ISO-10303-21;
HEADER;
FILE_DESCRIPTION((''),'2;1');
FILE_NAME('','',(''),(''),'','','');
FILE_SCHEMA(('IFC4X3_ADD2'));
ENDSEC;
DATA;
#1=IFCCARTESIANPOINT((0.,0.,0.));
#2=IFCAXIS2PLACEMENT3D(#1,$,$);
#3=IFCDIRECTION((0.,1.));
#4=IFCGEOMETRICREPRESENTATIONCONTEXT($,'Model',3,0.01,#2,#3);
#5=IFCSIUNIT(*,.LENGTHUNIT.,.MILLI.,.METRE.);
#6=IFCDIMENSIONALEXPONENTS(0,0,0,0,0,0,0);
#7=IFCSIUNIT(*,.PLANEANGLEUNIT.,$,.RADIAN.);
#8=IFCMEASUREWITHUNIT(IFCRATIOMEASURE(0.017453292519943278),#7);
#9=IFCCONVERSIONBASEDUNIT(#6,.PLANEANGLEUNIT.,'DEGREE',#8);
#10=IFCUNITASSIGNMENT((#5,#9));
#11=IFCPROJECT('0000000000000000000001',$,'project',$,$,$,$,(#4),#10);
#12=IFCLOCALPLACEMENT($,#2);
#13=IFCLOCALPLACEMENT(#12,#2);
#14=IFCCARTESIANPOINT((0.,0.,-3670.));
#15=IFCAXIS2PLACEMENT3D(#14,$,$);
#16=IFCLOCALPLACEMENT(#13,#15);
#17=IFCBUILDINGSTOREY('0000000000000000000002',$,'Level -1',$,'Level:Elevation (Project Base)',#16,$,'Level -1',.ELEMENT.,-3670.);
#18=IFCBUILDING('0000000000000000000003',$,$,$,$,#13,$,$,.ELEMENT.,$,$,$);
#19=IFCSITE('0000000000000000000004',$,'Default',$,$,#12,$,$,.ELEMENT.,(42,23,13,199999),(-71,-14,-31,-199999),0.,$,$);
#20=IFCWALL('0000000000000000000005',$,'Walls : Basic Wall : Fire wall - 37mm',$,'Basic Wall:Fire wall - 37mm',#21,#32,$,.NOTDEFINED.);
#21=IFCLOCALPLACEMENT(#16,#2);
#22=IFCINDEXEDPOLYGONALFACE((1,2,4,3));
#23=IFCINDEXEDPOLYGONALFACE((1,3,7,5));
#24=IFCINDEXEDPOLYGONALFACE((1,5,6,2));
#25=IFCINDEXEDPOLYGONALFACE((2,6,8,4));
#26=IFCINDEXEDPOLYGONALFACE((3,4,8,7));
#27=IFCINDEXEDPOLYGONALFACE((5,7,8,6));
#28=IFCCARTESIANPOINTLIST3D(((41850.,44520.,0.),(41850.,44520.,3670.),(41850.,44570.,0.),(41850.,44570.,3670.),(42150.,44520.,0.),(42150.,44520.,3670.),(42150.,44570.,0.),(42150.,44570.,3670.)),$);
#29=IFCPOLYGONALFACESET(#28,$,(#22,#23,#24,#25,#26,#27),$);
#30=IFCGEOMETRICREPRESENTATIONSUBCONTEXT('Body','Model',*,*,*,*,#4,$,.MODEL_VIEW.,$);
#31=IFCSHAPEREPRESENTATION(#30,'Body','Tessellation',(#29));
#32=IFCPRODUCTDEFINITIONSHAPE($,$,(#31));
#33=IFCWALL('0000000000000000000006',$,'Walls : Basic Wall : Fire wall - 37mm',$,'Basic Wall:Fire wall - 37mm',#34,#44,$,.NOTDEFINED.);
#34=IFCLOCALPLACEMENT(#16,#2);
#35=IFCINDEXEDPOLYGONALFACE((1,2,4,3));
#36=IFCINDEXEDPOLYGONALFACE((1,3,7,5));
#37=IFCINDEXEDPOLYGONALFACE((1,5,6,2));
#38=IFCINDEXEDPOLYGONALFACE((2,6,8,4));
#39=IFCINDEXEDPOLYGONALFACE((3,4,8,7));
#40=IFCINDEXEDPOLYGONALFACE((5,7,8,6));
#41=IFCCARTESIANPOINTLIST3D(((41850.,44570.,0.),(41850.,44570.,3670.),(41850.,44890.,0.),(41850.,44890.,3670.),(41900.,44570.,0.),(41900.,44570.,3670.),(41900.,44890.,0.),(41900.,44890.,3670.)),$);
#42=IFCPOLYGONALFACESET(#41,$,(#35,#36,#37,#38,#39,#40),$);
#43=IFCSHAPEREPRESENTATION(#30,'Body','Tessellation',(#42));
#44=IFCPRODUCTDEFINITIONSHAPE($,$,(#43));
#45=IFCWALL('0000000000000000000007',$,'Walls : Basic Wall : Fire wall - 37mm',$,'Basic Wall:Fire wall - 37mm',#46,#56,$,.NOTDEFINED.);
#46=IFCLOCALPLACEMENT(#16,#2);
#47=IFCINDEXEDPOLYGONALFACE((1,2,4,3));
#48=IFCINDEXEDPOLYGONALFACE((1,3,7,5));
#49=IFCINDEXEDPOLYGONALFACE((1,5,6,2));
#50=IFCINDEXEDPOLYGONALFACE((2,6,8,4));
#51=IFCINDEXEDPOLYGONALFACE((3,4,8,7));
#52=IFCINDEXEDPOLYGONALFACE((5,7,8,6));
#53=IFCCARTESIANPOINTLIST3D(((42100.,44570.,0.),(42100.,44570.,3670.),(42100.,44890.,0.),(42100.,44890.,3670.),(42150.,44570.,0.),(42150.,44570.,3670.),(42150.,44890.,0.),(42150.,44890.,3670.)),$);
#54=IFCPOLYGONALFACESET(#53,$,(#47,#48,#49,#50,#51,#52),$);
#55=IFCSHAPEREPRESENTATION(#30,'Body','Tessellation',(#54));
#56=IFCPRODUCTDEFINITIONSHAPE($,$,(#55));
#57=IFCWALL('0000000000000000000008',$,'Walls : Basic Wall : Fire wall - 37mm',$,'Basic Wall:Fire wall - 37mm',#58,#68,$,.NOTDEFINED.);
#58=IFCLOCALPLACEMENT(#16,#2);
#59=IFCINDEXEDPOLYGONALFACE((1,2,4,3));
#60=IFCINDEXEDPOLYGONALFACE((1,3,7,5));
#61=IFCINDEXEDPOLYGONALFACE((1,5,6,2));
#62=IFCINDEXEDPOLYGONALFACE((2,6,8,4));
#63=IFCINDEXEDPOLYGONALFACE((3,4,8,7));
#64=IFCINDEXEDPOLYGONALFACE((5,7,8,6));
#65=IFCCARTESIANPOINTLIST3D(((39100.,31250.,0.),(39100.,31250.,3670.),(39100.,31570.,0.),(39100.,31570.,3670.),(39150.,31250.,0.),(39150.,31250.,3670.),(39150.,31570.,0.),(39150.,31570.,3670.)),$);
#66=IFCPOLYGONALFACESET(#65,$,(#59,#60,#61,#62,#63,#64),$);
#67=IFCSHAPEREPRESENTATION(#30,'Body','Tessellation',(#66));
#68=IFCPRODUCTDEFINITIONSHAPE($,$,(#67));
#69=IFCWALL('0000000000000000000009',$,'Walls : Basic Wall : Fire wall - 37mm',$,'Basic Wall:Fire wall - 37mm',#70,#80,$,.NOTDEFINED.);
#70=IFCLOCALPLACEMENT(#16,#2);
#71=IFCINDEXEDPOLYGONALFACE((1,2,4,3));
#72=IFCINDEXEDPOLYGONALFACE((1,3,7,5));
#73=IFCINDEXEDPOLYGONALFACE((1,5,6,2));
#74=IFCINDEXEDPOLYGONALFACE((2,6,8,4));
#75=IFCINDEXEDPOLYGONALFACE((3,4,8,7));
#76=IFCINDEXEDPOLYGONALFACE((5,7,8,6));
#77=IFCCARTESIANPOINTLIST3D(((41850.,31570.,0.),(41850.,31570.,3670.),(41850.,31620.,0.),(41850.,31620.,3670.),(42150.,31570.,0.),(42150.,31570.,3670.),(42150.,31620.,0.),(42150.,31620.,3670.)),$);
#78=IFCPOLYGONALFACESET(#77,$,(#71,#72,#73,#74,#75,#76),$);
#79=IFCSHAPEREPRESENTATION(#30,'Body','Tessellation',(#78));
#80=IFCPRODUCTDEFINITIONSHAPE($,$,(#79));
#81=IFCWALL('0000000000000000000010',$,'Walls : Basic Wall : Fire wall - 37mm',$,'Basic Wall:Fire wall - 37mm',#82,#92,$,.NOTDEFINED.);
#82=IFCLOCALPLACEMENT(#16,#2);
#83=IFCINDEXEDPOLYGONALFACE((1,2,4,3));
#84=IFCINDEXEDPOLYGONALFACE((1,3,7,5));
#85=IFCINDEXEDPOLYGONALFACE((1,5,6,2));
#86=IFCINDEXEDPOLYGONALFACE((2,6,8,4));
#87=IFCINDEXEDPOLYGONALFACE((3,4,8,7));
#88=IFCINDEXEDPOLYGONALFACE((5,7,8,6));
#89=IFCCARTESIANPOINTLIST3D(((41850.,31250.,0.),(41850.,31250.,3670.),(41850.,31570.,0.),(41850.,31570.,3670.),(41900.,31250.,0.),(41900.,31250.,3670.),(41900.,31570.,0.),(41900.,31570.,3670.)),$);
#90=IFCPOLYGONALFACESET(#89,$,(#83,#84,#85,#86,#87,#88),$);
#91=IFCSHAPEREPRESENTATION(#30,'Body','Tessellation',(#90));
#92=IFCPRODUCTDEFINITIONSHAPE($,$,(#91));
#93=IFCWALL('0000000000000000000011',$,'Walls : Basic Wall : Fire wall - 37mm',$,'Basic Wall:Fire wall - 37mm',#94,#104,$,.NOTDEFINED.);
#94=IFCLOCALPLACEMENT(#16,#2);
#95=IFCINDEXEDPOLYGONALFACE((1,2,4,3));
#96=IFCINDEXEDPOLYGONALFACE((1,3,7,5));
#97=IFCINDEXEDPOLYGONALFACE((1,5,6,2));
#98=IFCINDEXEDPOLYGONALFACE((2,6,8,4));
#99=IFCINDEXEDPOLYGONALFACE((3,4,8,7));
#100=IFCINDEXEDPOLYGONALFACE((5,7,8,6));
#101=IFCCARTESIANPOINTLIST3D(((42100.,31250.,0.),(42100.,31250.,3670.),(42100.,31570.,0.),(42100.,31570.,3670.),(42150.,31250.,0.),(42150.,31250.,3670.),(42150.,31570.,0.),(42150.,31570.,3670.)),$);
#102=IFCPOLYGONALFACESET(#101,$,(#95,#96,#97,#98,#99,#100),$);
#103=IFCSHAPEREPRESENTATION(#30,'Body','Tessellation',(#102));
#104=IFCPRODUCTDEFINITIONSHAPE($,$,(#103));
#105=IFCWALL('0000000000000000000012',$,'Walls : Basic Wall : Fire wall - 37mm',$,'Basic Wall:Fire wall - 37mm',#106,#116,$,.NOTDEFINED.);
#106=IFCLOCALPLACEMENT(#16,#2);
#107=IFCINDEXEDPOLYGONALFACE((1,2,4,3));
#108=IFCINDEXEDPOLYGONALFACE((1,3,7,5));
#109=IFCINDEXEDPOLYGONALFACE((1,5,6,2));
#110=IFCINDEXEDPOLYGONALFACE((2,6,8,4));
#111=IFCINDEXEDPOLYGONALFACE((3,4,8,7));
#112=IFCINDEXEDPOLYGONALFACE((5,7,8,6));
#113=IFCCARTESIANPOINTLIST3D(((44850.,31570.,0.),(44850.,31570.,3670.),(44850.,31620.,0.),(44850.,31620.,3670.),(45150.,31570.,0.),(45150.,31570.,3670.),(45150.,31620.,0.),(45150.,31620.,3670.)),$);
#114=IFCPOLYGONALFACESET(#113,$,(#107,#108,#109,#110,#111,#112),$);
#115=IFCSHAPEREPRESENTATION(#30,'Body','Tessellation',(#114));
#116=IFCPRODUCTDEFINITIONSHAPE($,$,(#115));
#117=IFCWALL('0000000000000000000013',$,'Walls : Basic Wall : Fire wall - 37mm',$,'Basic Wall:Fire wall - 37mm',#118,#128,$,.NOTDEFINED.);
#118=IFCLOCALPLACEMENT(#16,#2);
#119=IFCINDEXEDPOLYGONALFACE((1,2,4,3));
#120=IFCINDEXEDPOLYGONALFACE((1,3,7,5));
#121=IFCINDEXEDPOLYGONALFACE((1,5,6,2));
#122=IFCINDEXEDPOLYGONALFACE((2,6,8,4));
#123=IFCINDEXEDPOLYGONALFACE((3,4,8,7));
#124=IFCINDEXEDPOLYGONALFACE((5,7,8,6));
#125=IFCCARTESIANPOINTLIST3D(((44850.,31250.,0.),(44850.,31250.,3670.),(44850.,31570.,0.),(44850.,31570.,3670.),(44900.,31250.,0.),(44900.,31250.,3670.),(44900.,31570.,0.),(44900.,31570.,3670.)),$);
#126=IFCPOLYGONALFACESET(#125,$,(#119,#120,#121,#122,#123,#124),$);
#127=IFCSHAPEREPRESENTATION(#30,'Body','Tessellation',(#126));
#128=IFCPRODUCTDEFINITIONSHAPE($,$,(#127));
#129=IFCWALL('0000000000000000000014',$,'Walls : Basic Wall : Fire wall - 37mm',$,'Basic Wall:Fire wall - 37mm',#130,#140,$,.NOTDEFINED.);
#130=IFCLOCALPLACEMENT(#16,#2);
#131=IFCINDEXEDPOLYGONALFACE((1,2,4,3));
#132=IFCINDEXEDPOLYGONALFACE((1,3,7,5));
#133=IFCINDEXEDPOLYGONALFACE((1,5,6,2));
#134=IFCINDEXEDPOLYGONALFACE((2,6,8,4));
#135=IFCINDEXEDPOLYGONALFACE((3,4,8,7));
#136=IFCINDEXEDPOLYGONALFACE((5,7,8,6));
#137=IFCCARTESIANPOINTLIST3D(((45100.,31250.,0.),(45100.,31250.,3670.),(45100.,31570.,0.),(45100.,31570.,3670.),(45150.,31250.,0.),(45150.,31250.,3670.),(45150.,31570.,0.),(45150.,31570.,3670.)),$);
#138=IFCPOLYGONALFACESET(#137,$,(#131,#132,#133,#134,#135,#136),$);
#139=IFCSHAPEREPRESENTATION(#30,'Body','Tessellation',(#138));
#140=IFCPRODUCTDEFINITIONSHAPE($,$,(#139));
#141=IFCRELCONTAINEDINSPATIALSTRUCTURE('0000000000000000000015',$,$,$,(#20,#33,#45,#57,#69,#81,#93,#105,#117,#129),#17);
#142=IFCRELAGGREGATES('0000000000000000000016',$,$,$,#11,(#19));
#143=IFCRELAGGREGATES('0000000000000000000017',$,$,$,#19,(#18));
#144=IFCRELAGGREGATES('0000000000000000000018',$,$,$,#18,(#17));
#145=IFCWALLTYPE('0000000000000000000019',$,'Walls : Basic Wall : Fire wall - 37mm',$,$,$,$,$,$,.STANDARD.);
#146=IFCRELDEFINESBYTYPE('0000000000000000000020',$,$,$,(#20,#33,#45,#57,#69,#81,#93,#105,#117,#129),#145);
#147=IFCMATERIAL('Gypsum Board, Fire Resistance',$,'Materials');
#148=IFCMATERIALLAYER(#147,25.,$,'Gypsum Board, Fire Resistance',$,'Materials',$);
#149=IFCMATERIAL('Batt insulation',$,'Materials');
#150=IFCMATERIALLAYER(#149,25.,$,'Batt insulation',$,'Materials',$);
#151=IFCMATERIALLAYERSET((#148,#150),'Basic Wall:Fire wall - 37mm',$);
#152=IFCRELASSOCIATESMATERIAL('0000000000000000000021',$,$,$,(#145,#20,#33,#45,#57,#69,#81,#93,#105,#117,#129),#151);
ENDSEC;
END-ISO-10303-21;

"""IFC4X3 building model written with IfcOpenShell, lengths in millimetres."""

from ifc_helpers import new_model, entity, si_unit, converted_unit, direction, frame, frame_2d, origin, place, context, subcontext, project, spatial, rectangle, extrude, material, layer, layer_set, type_object, element, save


model = new_model("IFC4X3")

# Units and contexts
model_context = context("Model", 3, precision=0.01, world=origin(), true_north=direction((0.0, 1.0)))
body_context = subcontext(model_context, "Body", "Model", "MODEL_VIEW")
ifc_project = project(units=[si_unit("LENGTHUNIT", "METRE", prefix="MILLI"), converted_unit("PLANEANGLEUNIT", "DEGREE", entity("IfcRatioMeasure", 0.017453292519943278), si_unit("PLANEANGLEUNIT", "RADIAN"), dimensions=[0, 0, 0, 0, 0, 0, 0])], contexts=[model_context])

# Site, building, storey
site_placement = place(None, origin())
site = spatial("IfcSite", under=ifc_project, at=site_placement, Name="Default", CompositionType="ELEMENT", RefLatitude=(42, 23, 13, 199999), RefLongitude=(-71, -14, -31, -199999), RefElevation=0.0)
building_placement = place(site_placement, origin())
building = spatial("IfcBuilding", under=site, at=building_placement, CompositionType="ELEMENT")
storey_placement = place(building_placement, frame((0.0, 0.0, -3670.0)))
storey = spatial("IfcBuildingStorey", under=building, at=storey_placement, Name="Level -1", ObjectType="Level:Elevation (Project Base)", LongName="Level -1", CompositionType="ELEMENT", Elevation=-3670.0)

# Walls
ifc_material_1 = material(Name="Gypsum Board, Fire Resistance", Category="Materials")
ifc_layer_1 = layer(ifc_material_1, 25.0, Name="Gypsum Board, Fire Resistance", Category="Materials")
ifc_material_2 = material(Name="Batt insulation", Category="Materials")
ifc_layer_2 = layer(ifc_material_2, 25.0, Name="Batt insulation", Category="Materials")
ifc_layer_set_1 = layer_set([ifc_layer_1, ifc_layer_2], Name="Basic Wall:Fire wall - 37mm")
wall_type_1 = type_object("IfcWallType", Name="Walls : Basic Wall : Fire wall - 37mm", PredefinedType="STANDARD", material=ifc_layer_set_1)
wall_1_placement = place(storey_placement, frame((41850.0, 44545.0, 0.0)))
element("IfcWall", 1, at=wall_1_placement, inside=storey, type_object=wall_type_1, material=ifc_layer_set_1, Name="Walls : Basic Wall : Fire wall - 37mm", ObjectType="Basic Wall:Fire wall - 37mm", PredefinedType="NOTDEFINED", context=body_context, shape_type="SweptSolid", body=[
    extrude(rectangle(XDim=300.0, YDim=50.0, at=frame_2d((150.0, 0.0), x_axis=(-1.0, 0.0))), origin(), (0.0, 0.0, 1.0), 3670.0),
])
wall_2_placement = place(storey_placement, frame((41875.0, 44890.0, 0.0), z_axis=(0.0, 0.0, 1.0), x_axis=(0.0, -1.0, 0.0)))
element("IfcWall", 2, at=wall_2_placement, inside=storey, type_object=wall_type_1, material=ifc_layer_set_1, Name="Walls : Basic Wall : Fire wall - 37mm", ObjectType="Basic Wall:Fire wall - 37mm", PredefinedType="NOTDEFINED", context=body_context, shape_type="SweptSolid", body=[
    extrude(rectangle(XDim=320.0, YDim=50.0, at=frame_2d((160.0, 0.0), x_axis=(-1.0, 0.0))), origin(), (0.0, 0.0, 1.0), 3670.0),
])
wall_3_placement = place(storey_placement, frame((42125.0, 44890.0, 0.0), z_axis=(0.0, 0.0, 1.0), x_axis=(0.0, -1.0, 0.0)))
element("IfcWall", 3, at=wall_3_placement, inside=storey, type_object=wall_type_1, material=ifc_layer_set_1, Name="Walls : Basic Wall : Fire wall - 37mm", ObjectType="Basic Wall:Fire wall - 37mm", PredefinedType="NOTDEFINED", context=body_context, shape_type="SweptSolid", body=[
    extrude(rectangle(XDim=320.0, YDim=50.0, at=frame_2d((160.0, 0.0), x_axis=(-1.0, 0.0))), origin(), (0.0, 0.0, 1.0), 3670.0),
])
wall_4_placement = place(storey_placement, frame((39125.0, 31570.0, 0.0), z_axis=(0.0, 0.0, 1.0), x_axis=(0.0, -1.0, 0.0)))
element("IfcWall", 4, at=wall_4_placement, inside=storey, type_object=wall_type_1, material=ifc_layer_set_1, Name="Walls : Basic Wall : Fire wall - 37mm", ObjectType="Basic Wall:Fire wall - 37mm", PredefinedType="NOTDEFINED", context=body_context, shape_type="SweptSolid", body=[
    extrude(rectangle(XDim=320.0, YDim=50.0, at=frame_2d((160.0, 0.0), x_axis=(-1.0, 0.0))), origin(), (0.0, 0.0, 1.0), 3670.0),
])
wall_5_placement = place(storey_placement, frame((41850.0, 31595.0, 0.0)))
element("IfcWall", 5, at=wall_5_placement, inside=storey, type_object=wall_type_1, material=ifc_layer_set_1, Name="Walls : Basic Wall : Fire wall - 37mm", ObjectType="Basic Wall:Fire wall - 37mm", PredefinedType="NOTDEFINED", context=body_context, shape_type="SweptSolid", body=[
    extrude(rectangle(XDim=300.0, YDim=50.0, at=frame_2d((150.0, 0.0), x_axis=(-1.0, 0.0))), origin(), (0.0, 0.0, 1.0), 3670.0),
])
for number, where, z_axis, x_axis, name in (
    (6, (41875.0, 31570.0, 0.0), (0.0, 0.0, 1.0), (0.0, -1.0, 0.0), "Walls : Basic Wall : Fire wall - 37mm"),
    (7, (42125.0, 31570.0, 0.0), (0.0, 0.0, 1.0), (0.0, -1.0, 0.0), "Walls : Basic Wall : Fire wall - 37mm"),
):
    element("IfcWall", number, at=place(storey_placement, frame(where, z_axis=z_axis, x_axis=x_axis)), inside=storey, type_object=wall_type_1, material=ifc_layer_set_1, Name=name, ObjectType="Basic Wall:Fire wall - 37mm", PredefinedType="NOTDEFINED", context=body_context, shape_type="SweptSolid", body=[
        extrude(rectangle(XDim=320.0, YDim=50.0, at=frame_2d((160.0, 0.0), x_axis=(-1.0, 0.0))), origin(), (0.0, 0.0, 1.0), 3670.0),
    ])
wall_6_placement = place(storey_placement, frame((44850.0, 31595.0, 0.0)))
element("IfcWall", 8, at=wall_6_placement, inside=storey, type_object=wall_type_1, material=ifc_layer_set_1, Name="Walls : Basic Wall : Fire wall - 37mm", ObjectType="Basic Wall:Fire wall - 37mm", PredefinedType="NOTDEFINED", context=body_context, shape_type="SweptSolid", body=[
    extrude(rectangle(XDim=300.0, YDim=50.0, at=frame_2d((150.0, 0.0), x_axis=(-1.0, 0.0))), origin(), (0.0, 0.0, 1.0), 3670.0),
])
for number, where, z_axis, x_axis, name in (
    (9, (44875.0, 31570.0, 0.0), (0.0, 0.0, 1.0), (0.0, -1.0, 0.0), "Walls : Basic Wall : Fire wall - 37mm"),
    (10, (45125.0, 31570.0, 0.0), (0.0, 0.0, 1.0), (0.0, -1.0, 0.0), "Walls : Basic Wall : Fire wall - 37mm"),
):
    element("IfcWall", number, at=place(storey_placement, frame(where, z_axis=z_axis, x_axis=x_axis)), inside=storey, type_object=wall_type_1, material=ifc_layer_set_1, Name=name, ObjectType="Basic Wall:Fire wall - 37mm", PredefinedType="NOTDEFINED", context=body_context, shape_type="SweptSolid", body=[
        extrude(rectangle(XDim=320.0, YDim=50.0, at=frame_2d((160.0, 0.0), x_axis=(-1.0, 0.0))), origin(), (0.0, 0.0, 1.0), 3670.0),
    ])

save(model, "model.ifc")
